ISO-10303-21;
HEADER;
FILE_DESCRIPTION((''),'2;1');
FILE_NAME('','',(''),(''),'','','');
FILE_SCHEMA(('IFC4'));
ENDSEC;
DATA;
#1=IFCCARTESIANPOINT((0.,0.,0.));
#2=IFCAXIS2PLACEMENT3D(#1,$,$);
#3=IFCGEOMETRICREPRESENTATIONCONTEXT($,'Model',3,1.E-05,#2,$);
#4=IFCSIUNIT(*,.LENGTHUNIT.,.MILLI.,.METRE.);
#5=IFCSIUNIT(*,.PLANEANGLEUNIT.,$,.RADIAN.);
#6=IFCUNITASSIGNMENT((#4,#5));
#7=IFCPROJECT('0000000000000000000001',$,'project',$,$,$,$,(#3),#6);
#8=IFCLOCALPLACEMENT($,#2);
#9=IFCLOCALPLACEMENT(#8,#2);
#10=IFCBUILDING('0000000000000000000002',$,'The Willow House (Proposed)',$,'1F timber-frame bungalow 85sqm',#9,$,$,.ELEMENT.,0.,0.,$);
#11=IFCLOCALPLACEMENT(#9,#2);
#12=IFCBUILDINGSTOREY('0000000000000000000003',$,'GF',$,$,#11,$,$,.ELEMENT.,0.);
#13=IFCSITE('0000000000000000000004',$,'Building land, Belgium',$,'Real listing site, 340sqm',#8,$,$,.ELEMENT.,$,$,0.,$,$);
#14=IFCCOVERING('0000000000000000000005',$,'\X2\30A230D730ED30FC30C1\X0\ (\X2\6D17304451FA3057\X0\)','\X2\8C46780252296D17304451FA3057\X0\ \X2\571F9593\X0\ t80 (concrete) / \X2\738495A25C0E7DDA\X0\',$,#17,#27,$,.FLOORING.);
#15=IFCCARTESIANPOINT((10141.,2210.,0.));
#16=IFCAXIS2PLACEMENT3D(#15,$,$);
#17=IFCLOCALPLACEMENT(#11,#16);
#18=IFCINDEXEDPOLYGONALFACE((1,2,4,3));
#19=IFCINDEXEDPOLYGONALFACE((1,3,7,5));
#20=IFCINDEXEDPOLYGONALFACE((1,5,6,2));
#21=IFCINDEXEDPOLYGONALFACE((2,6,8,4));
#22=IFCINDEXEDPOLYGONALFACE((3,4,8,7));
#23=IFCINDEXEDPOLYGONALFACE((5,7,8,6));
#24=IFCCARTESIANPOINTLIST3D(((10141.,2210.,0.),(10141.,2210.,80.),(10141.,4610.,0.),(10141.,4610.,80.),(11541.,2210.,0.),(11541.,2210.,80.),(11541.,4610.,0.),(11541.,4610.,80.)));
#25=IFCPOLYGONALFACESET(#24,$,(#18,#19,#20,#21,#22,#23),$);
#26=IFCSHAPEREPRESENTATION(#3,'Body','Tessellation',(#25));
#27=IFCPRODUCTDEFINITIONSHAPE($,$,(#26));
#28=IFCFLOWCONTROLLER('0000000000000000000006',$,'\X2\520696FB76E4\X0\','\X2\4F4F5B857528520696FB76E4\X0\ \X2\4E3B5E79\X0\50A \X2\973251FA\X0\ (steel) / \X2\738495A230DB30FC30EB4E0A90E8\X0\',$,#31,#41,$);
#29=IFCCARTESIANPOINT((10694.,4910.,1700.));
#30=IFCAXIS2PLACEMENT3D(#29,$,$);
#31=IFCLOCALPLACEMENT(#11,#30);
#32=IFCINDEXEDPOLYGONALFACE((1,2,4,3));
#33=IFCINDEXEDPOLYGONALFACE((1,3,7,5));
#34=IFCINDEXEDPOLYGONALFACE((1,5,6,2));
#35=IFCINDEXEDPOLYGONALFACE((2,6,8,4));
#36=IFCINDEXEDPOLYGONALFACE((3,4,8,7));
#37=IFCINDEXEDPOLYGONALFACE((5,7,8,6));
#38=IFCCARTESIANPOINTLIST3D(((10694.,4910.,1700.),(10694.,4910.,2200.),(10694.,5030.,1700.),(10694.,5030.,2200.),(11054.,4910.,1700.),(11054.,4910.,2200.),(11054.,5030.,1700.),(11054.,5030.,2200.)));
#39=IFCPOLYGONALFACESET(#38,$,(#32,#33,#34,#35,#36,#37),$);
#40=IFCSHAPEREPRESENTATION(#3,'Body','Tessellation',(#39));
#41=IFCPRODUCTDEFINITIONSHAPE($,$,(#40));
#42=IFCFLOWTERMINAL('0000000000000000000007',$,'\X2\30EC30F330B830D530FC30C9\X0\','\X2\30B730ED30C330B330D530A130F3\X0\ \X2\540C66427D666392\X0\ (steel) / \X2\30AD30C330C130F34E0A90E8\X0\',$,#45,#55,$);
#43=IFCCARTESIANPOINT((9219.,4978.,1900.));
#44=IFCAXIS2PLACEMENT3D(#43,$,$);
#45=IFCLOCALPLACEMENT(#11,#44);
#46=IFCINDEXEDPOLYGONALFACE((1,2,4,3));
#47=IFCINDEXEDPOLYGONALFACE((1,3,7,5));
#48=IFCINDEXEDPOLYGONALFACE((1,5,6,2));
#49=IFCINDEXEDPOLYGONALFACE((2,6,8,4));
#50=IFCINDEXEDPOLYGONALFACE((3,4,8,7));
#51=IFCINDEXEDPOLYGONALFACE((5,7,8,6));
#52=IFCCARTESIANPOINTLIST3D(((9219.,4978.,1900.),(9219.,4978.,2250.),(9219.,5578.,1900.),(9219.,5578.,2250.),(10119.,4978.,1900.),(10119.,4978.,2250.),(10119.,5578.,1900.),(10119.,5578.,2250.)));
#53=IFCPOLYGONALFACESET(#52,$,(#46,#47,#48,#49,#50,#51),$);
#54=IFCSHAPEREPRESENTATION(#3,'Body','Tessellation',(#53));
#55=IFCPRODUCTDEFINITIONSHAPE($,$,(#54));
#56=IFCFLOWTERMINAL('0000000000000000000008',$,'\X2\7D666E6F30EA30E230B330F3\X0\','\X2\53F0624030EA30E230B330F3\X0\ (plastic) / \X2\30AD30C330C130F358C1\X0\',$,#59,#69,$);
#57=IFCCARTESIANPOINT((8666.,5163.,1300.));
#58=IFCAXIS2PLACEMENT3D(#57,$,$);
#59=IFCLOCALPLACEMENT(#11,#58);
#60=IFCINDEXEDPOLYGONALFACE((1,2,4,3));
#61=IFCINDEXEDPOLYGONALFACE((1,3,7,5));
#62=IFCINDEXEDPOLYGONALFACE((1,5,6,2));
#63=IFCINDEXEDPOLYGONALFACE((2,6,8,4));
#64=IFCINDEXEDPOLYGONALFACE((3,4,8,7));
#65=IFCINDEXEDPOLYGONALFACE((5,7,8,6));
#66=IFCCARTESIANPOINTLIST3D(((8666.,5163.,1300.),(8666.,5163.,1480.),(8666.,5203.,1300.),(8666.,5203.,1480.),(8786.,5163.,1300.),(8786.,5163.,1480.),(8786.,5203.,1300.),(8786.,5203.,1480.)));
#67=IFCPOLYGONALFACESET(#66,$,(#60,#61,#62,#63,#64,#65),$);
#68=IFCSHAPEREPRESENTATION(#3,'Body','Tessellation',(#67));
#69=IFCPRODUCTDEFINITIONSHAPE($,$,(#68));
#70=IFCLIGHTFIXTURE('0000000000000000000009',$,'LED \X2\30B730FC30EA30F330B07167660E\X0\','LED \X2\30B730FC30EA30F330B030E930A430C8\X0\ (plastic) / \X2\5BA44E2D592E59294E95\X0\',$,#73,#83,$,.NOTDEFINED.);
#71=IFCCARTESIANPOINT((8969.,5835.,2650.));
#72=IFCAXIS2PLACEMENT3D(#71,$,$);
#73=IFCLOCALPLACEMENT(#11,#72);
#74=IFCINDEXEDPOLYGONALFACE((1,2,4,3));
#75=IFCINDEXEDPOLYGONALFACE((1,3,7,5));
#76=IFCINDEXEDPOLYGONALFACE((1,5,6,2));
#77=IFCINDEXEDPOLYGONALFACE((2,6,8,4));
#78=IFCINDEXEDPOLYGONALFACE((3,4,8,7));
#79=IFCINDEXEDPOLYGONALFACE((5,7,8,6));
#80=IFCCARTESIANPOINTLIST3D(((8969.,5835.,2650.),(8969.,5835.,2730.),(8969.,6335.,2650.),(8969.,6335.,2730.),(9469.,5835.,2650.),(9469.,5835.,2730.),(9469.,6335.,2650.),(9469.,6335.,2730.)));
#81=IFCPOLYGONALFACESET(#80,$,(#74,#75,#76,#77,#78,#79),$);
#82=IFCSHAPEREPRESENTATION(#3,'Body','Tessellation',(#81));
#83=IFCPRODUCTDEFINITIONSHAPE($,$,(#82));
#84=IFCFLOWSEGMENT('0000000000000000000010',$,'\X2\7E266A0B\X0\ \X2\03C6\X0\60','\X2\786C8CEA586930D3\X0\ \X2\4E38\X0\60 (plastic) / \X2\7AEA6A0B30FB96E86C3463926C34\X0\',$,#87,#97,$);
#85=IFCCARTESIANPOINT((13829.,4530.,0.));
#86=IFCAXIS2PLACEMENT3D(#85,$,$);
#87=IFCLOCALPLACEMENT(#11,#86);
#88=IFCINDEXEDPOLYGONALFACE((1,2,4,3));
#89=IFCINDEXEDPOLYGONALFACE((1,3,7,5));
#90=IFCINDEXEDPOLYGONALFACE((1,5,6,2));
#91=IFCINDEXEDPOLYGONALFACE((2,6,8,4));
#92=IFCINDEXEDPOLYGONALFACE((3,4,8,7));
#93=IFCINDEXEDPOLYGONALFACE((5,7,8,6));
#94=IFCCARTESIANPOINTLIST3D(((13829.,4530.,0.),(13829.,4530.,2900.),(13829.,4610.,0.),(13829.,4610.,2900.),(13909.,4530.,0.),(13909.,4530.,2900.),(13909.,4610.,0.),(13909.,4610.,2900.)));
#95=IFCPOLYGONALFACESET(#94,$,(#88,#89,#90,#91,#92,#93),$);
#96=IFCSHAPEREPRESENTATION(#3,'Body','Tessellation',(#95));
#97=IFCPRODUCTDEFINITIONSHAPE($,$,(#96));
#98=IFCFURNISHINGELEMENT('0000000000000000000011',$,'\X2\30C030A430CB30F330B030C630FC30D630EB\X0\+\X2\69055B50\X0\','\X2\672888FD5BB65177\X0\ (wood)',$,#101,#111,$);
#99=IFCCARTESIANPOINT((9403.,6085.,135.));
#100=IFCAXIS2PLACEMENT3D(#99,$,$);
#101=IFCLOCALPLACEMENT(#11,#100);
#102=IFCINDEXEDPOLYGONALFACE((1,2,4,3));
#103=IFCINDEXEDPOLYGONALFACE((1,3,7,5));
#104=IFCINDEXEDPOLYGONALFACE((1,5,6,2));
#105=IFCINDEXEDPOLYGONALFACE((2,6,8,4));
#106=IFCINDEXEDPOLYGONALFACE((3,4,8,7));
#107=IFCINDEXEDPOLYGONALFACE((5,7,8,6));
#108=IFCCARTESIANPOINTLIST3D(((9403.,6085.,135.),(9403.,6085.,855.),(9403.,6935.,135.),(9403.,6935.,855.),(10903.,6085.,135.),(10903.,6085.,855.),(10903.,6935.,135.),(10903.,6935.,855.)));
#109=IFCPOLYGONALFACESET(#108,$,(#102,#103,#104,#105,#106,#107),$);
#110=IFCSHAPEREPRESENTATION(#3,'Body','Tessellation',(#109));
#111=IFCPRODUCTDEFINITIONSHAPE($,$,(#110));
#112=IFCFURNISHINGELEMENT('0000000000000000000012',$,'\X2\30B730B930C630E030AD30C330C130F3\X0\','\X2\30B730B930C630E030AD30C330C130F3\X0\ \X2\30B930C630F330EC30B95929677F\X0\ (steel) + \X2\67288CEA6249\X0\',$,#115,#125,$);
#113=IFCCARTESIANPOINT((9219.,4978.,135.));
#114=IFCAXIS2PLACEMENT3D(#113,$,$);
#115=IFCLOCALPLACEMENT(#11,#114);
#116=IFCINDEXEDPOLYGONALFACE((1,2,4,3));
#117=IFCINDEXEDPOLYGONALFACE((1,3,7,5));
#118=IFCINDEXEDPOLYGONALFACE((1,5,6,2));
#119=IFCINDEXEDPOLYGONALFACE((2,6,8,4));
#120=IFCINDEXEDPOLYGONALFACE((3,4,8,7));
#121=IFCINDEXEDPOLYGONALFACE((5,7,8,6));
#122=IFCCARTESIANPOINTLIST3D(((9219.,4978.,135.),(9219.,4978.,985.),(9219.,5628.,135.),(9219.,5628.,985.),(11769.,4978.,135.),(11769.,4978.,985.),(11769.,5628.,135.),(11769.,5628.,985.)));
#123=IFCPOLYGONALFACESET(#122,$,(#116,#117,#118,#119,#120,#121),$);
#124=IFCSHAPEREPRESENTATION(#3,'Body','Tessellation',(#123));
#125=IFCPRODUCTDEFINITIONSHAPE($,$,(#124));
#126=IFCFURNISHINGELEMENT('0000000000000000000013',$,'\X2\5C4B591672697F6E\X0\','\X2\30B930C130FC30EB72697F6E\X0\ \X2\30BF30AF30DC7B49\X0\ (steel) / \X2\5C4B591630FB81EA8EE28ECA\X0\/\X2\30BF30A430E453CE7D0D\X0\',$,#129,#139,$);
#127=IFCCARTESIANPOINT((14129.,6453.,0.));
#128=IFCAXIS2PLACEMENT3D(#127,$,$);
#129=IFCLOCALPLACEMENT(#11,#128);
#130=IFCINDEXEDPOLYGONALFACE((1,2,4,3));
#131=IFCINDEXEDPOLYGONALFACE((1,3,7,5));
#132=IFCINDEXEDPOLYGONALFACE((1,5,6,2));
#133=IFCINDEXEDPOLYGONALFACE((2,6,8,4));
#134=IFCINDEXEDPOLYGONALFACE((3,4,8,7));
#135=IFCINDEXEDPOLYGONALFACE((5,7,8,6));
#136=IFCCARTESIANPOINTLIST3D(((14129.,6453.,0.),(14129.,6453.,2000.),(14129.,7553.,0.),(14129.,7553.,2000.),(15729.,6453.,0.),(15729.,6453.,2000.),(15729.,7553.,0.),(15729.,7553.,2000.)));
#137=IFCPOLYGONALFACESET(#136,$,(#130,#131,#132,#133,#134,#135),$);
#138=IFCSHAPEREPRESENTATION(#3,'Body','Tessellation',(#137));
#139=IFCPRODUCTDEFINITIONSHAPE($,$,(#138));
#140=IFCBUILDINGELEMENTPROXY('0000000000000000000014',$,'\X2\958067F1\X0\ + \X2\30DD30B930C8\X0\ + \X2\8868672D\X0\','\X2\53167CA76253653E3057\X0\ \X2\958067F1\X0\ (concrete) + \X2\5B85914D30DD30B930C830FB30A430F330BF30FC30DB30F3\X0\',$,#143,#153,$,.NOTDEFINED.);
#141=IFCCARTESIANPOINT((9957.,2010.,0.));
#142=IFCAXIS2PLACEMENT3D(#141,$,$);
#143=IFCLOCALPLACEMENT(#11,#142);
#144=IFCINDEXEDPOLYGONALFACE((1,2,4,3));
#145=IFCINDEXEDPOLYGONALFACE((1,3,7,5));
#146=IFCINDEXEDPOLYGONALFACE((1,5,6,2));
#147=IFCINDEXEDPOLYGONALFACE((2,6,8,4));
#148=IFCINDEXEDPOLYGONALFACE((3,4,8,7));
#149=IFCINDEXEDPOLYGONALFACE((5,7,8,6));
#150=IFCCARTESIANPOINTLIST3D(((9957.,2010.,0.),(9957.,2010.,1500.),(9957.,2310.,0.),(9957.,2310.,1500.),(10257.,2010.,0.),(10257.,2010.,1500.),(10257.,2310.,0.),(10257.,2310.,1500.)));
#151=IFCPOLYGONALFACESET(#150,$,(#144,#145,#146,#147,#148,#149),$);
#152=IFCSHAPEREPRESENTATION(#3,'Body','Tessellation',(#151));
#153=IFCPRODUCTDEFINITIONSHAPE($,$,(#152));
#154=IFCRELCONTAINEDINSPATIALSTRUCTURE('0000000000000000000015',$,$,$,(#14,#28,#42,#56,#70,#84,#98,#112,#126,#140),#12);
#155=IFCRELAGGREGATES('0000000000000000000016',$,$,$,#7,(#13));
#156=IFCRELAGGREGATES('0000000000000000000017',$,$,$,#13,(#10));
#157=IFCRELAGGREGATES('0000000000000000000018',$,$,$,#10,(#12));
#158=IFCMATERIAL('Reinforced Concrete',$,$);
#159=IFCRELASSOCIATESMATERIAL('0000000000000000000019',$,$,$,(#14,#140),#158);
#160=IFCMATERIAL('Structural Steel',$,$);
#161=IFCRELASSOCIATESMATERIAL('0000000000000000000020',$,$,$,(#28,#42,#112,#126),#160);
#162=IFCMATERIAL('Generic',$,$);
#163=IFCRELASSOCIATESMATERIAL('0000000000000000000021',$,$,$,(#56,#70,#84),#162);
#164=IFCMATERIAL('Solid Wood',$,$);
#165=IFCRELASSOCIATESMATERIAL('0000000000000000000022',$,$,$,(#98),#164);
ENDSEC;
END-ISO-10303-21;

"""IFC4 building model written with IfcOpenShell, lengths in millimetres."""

from ifc_helpers import new_model, si_unit, frame, frame_2d, origin, place, context, project, spatial, rectangle, extrude, material, element, save


model = new_model("IFC4")

# Units and contexts
model_context = context("Model", 3, precision=1e-05, world=origin())
ifc_project = project(units=[si_unit("LENGTHUNIT", "METRE", prefix="MILLI"), si_unit("PLANEANGLEUNIT", "RADIAN")], contexts=[model_context])

# Site, building, storey
site_placement = place(None, origin())
site = spatial("IfcSite", under=ifc_project, at=site_placement, Name="Building land, Belgium", ObjectType="Real listing site, 340sqm", CompositionType="ELEMENT", RefElevation=0.0)
building_placement = place(site_placement, origin())
building = spatial("IfcBuilding", under=site, at=building_placement, Name="The Willow House (Proposed)", ObjectType="1F timber-frame bungalow 85sqm", CompositionType="ELEMENT", ElevationOfRefHeight=0.0, ElevationOfTerrain=0.0)
storey_placement = place(building_placement, origin())
storey = spatial("IfcBuildingStorey", under=building, at=storey_placement, Name="GF", CompositionType="ELEMENT", Elevation=0.0)

# Shared definitions
ifc_material_1 = material(Name="Solid Wood")

# Shared definitions
ifc_material_2 = material(Name="Structural Steel")

# Covering
ifc_material_3 = material(Name="Reinforced Concrete")
covering_placement = place(storey_placement, frame((10141.0, 2210.0, 0.0)))
element("IfcCovering", 1, at=covering_placement, inside=storey, material=ifc_material_3, Name="アプローチ (洗い出し)", Description="豆砂利洗い出し 土間 t80 (concrete) / 玄関導線", PredefinedType="FLOORING", context=model_context, shape_type="SweptSolid", body=[
    extrude(rectangle(XDim=1400.0, YDim=2400.0, at=frame_2d((700.0, 1200.0))), frame((10141.0, 2210.0, 0.0)), (0.0, 0.0, 1.0), 80.0),
])

# Flow controller
flow_controller_placement = place(storey_placement, frame((10694.0, 4910.0, 1700.0)))
element("IfcFlowController", 2, at=flow_controller_placement, inside=storey, material=ifc_material_2, Name="分電盤", Description="住宅用分電盤 主幹50A 露出 (steel) / 玄関ホール上部", context=model_context, shape_type="SweptSolid", body=[
    extrude(rectangle(XDim=360.0, YDim=120.0, at=frame_2d((180.0, 60.0))), frame((10694.0, 4910.0, 1700.0)), (0.0, 0.0, 1.0), 500.0),
])

# Flow terminals
flow_terminal_1_placement = place(storey_placement, frame((9219.0, 4978.0, 1900.0)))
element("IfcFlowTerminal", 3, at=flow_terminal_1_placement, inside=storey, material=ifc_material_2, Name="レンジフード", Description="シロッコファン 同時給排 (steel) / キッチン上部", context=model_context, shape_type="SweptSolid", body=[
    extrude(rectangle(XDim=900.0, YDim=600.0, at=frame_2d((450.0, 300.0))), frame((9219.0, 4978.0, 1900.0)), (0.0, 0.0, 1.0), 350.0),
])
ifc_material_4 = material(Name="Generic")
flow_terminal_2_placement = place(storey_placement, frame((8666.0, 5163.0, 1300.0)))
element("IfcFlowTerminal", 4, at=flow_terminal_2_placement, inside=storey, material=ifc_material_4, Name="給湯リモコン", Description="台所リモコン (plastic) / キッチン壁", context=model_context, shape_type="SweptSolid", body=[
    extrude(rectangle(XDim=120.0, YDim=40.0, at=frame_2d((60.0, 20.0))), frame((8666.0, 5163.0, 1300.0)), (0.0, 0.0, 1.0), 180.0),
])

# Light fixture
light_fixture_placement = place(storey_placement, frame((8969.0, 5835.0, 2650.0)))
element("IfcLightFixture", 5, at=light_fixture_placement, inside=storey, material=ifc_material_4, Name="LED シーリング照明", Description="LED シーリングライト (plastic) / 室中央天井", PredefinedType="NOTDEFINED", context=model_context, shape_type="SweptSolid", body=[
    extrude(rectangle(XDim=500.0, YDim=500.0, at=frame_2d((250.0, 250.0))), frame((8969.0, 5835.0, 2650.0)), (0.0, 0.0, 1.0), 80.0),
])

# Flow segment
flow_segment_placement = place(storey_placement, frame((13829.0, 4530.0, 0.0)))
element("IfcFlowSegment", 6, at=flow_segment_placement, inside=storey, material=ifc_material_4, Name="縦樋 φ60", Description="硬質塩ビ 丸60 (plastic) / 竪樋・雨水排水", context=model_context, shape_type="SweptSolid", body=[
    extrude(rectangle(XDim=80.0, YDim=80.0, at=frame_2d((40.0, 40.0))), frame((13829.0, 4530.0, 0.0)), (0.0, 0.0, 1.0), 2900.0),
])

# Furnishing elements
furnishing_1_placement = place(storey_placement, frame((9403.0, 6085.0, 135.0)))
element("IfcFurnishingElement", 7, at=furnishing_1_placement, inside=storey, material=ifc_material_1, Name="ダイニングテーブル+椅子", Description="木製家具 (wood)", context=model_context, shape_type="SweptSolid", body=[
    extrude(rectangle(XDim=1500.0, YDim=850.0, at=frame_2d((750.0, 425.0))), frame((9403.0, 6085.0, 135.0)), (0.0, 0.0, 1.0), 720.0),
])
furnishing_2_placement = place(storey_placement, frame((9219.0, 4978.0, 135.0)))
element("IfcFurnishingElement", 8, at=furnishing_2_placement, inside=storey, material=ifc_material_2, Name="システムキッチン", Description="システムキッチン ステンレス天板 (steel) + 木質扉", context=model_context, shape_type="SweptSolid", body=[
    extrude(rectangle(XDim=2550.0, YDim=650.0, at=frame_2d((1275.0, 325.0))), frame((9219.0, 4978.0, 135.0)), (0.0, 0.0, 1.0), 850.0),
])
furnishing_3_placement = place(storey_placement, frame((14129.0, 6453.0, 0.0)))
element("IfcFurnishingElement", 9, at=furnishing_3_placement, inside=storey, material=ifc_material_2, Name="屋外物置", Description="スチール物置 タクボ等 (steel) / 屋外・自転車/タイヤ収納", context=model_context, shape_type="SweptSolid", body=[
    extrude(rectangle(XDim=1600.0, YDim=1100.0, at=frame_2d((800.0, 550.0))), frame((14129.0, 6453.0, 0.0)), (0.0, 0.0, 1.0), 2000.0),
])

# Building element proxy
proxy_placement = place(storey_placement, frame((9957.0, 2010.0, 0.0)))
element("IfcBuildingElementProxy", 10, at=proxy_placement, inside=storey, material=ifc_material_3, Name="門柱 + ポスト + 表札", Description="化粧打放し 門柱 (concrete) + 宅配ポスト・インターホン", PredefinedType="NOTDEFINED", context=model_context, shape_type="SweptSolid", body=[
    extrude(rectangle(XDim=300.0, YDim=300.0, at=frame_2d((150.0, 150.0))), frame((9957.0, 2010.0, 0.0)), (0.0, 0.0, 1.0), 1500.0),
])

save(model, "model.ifc")
